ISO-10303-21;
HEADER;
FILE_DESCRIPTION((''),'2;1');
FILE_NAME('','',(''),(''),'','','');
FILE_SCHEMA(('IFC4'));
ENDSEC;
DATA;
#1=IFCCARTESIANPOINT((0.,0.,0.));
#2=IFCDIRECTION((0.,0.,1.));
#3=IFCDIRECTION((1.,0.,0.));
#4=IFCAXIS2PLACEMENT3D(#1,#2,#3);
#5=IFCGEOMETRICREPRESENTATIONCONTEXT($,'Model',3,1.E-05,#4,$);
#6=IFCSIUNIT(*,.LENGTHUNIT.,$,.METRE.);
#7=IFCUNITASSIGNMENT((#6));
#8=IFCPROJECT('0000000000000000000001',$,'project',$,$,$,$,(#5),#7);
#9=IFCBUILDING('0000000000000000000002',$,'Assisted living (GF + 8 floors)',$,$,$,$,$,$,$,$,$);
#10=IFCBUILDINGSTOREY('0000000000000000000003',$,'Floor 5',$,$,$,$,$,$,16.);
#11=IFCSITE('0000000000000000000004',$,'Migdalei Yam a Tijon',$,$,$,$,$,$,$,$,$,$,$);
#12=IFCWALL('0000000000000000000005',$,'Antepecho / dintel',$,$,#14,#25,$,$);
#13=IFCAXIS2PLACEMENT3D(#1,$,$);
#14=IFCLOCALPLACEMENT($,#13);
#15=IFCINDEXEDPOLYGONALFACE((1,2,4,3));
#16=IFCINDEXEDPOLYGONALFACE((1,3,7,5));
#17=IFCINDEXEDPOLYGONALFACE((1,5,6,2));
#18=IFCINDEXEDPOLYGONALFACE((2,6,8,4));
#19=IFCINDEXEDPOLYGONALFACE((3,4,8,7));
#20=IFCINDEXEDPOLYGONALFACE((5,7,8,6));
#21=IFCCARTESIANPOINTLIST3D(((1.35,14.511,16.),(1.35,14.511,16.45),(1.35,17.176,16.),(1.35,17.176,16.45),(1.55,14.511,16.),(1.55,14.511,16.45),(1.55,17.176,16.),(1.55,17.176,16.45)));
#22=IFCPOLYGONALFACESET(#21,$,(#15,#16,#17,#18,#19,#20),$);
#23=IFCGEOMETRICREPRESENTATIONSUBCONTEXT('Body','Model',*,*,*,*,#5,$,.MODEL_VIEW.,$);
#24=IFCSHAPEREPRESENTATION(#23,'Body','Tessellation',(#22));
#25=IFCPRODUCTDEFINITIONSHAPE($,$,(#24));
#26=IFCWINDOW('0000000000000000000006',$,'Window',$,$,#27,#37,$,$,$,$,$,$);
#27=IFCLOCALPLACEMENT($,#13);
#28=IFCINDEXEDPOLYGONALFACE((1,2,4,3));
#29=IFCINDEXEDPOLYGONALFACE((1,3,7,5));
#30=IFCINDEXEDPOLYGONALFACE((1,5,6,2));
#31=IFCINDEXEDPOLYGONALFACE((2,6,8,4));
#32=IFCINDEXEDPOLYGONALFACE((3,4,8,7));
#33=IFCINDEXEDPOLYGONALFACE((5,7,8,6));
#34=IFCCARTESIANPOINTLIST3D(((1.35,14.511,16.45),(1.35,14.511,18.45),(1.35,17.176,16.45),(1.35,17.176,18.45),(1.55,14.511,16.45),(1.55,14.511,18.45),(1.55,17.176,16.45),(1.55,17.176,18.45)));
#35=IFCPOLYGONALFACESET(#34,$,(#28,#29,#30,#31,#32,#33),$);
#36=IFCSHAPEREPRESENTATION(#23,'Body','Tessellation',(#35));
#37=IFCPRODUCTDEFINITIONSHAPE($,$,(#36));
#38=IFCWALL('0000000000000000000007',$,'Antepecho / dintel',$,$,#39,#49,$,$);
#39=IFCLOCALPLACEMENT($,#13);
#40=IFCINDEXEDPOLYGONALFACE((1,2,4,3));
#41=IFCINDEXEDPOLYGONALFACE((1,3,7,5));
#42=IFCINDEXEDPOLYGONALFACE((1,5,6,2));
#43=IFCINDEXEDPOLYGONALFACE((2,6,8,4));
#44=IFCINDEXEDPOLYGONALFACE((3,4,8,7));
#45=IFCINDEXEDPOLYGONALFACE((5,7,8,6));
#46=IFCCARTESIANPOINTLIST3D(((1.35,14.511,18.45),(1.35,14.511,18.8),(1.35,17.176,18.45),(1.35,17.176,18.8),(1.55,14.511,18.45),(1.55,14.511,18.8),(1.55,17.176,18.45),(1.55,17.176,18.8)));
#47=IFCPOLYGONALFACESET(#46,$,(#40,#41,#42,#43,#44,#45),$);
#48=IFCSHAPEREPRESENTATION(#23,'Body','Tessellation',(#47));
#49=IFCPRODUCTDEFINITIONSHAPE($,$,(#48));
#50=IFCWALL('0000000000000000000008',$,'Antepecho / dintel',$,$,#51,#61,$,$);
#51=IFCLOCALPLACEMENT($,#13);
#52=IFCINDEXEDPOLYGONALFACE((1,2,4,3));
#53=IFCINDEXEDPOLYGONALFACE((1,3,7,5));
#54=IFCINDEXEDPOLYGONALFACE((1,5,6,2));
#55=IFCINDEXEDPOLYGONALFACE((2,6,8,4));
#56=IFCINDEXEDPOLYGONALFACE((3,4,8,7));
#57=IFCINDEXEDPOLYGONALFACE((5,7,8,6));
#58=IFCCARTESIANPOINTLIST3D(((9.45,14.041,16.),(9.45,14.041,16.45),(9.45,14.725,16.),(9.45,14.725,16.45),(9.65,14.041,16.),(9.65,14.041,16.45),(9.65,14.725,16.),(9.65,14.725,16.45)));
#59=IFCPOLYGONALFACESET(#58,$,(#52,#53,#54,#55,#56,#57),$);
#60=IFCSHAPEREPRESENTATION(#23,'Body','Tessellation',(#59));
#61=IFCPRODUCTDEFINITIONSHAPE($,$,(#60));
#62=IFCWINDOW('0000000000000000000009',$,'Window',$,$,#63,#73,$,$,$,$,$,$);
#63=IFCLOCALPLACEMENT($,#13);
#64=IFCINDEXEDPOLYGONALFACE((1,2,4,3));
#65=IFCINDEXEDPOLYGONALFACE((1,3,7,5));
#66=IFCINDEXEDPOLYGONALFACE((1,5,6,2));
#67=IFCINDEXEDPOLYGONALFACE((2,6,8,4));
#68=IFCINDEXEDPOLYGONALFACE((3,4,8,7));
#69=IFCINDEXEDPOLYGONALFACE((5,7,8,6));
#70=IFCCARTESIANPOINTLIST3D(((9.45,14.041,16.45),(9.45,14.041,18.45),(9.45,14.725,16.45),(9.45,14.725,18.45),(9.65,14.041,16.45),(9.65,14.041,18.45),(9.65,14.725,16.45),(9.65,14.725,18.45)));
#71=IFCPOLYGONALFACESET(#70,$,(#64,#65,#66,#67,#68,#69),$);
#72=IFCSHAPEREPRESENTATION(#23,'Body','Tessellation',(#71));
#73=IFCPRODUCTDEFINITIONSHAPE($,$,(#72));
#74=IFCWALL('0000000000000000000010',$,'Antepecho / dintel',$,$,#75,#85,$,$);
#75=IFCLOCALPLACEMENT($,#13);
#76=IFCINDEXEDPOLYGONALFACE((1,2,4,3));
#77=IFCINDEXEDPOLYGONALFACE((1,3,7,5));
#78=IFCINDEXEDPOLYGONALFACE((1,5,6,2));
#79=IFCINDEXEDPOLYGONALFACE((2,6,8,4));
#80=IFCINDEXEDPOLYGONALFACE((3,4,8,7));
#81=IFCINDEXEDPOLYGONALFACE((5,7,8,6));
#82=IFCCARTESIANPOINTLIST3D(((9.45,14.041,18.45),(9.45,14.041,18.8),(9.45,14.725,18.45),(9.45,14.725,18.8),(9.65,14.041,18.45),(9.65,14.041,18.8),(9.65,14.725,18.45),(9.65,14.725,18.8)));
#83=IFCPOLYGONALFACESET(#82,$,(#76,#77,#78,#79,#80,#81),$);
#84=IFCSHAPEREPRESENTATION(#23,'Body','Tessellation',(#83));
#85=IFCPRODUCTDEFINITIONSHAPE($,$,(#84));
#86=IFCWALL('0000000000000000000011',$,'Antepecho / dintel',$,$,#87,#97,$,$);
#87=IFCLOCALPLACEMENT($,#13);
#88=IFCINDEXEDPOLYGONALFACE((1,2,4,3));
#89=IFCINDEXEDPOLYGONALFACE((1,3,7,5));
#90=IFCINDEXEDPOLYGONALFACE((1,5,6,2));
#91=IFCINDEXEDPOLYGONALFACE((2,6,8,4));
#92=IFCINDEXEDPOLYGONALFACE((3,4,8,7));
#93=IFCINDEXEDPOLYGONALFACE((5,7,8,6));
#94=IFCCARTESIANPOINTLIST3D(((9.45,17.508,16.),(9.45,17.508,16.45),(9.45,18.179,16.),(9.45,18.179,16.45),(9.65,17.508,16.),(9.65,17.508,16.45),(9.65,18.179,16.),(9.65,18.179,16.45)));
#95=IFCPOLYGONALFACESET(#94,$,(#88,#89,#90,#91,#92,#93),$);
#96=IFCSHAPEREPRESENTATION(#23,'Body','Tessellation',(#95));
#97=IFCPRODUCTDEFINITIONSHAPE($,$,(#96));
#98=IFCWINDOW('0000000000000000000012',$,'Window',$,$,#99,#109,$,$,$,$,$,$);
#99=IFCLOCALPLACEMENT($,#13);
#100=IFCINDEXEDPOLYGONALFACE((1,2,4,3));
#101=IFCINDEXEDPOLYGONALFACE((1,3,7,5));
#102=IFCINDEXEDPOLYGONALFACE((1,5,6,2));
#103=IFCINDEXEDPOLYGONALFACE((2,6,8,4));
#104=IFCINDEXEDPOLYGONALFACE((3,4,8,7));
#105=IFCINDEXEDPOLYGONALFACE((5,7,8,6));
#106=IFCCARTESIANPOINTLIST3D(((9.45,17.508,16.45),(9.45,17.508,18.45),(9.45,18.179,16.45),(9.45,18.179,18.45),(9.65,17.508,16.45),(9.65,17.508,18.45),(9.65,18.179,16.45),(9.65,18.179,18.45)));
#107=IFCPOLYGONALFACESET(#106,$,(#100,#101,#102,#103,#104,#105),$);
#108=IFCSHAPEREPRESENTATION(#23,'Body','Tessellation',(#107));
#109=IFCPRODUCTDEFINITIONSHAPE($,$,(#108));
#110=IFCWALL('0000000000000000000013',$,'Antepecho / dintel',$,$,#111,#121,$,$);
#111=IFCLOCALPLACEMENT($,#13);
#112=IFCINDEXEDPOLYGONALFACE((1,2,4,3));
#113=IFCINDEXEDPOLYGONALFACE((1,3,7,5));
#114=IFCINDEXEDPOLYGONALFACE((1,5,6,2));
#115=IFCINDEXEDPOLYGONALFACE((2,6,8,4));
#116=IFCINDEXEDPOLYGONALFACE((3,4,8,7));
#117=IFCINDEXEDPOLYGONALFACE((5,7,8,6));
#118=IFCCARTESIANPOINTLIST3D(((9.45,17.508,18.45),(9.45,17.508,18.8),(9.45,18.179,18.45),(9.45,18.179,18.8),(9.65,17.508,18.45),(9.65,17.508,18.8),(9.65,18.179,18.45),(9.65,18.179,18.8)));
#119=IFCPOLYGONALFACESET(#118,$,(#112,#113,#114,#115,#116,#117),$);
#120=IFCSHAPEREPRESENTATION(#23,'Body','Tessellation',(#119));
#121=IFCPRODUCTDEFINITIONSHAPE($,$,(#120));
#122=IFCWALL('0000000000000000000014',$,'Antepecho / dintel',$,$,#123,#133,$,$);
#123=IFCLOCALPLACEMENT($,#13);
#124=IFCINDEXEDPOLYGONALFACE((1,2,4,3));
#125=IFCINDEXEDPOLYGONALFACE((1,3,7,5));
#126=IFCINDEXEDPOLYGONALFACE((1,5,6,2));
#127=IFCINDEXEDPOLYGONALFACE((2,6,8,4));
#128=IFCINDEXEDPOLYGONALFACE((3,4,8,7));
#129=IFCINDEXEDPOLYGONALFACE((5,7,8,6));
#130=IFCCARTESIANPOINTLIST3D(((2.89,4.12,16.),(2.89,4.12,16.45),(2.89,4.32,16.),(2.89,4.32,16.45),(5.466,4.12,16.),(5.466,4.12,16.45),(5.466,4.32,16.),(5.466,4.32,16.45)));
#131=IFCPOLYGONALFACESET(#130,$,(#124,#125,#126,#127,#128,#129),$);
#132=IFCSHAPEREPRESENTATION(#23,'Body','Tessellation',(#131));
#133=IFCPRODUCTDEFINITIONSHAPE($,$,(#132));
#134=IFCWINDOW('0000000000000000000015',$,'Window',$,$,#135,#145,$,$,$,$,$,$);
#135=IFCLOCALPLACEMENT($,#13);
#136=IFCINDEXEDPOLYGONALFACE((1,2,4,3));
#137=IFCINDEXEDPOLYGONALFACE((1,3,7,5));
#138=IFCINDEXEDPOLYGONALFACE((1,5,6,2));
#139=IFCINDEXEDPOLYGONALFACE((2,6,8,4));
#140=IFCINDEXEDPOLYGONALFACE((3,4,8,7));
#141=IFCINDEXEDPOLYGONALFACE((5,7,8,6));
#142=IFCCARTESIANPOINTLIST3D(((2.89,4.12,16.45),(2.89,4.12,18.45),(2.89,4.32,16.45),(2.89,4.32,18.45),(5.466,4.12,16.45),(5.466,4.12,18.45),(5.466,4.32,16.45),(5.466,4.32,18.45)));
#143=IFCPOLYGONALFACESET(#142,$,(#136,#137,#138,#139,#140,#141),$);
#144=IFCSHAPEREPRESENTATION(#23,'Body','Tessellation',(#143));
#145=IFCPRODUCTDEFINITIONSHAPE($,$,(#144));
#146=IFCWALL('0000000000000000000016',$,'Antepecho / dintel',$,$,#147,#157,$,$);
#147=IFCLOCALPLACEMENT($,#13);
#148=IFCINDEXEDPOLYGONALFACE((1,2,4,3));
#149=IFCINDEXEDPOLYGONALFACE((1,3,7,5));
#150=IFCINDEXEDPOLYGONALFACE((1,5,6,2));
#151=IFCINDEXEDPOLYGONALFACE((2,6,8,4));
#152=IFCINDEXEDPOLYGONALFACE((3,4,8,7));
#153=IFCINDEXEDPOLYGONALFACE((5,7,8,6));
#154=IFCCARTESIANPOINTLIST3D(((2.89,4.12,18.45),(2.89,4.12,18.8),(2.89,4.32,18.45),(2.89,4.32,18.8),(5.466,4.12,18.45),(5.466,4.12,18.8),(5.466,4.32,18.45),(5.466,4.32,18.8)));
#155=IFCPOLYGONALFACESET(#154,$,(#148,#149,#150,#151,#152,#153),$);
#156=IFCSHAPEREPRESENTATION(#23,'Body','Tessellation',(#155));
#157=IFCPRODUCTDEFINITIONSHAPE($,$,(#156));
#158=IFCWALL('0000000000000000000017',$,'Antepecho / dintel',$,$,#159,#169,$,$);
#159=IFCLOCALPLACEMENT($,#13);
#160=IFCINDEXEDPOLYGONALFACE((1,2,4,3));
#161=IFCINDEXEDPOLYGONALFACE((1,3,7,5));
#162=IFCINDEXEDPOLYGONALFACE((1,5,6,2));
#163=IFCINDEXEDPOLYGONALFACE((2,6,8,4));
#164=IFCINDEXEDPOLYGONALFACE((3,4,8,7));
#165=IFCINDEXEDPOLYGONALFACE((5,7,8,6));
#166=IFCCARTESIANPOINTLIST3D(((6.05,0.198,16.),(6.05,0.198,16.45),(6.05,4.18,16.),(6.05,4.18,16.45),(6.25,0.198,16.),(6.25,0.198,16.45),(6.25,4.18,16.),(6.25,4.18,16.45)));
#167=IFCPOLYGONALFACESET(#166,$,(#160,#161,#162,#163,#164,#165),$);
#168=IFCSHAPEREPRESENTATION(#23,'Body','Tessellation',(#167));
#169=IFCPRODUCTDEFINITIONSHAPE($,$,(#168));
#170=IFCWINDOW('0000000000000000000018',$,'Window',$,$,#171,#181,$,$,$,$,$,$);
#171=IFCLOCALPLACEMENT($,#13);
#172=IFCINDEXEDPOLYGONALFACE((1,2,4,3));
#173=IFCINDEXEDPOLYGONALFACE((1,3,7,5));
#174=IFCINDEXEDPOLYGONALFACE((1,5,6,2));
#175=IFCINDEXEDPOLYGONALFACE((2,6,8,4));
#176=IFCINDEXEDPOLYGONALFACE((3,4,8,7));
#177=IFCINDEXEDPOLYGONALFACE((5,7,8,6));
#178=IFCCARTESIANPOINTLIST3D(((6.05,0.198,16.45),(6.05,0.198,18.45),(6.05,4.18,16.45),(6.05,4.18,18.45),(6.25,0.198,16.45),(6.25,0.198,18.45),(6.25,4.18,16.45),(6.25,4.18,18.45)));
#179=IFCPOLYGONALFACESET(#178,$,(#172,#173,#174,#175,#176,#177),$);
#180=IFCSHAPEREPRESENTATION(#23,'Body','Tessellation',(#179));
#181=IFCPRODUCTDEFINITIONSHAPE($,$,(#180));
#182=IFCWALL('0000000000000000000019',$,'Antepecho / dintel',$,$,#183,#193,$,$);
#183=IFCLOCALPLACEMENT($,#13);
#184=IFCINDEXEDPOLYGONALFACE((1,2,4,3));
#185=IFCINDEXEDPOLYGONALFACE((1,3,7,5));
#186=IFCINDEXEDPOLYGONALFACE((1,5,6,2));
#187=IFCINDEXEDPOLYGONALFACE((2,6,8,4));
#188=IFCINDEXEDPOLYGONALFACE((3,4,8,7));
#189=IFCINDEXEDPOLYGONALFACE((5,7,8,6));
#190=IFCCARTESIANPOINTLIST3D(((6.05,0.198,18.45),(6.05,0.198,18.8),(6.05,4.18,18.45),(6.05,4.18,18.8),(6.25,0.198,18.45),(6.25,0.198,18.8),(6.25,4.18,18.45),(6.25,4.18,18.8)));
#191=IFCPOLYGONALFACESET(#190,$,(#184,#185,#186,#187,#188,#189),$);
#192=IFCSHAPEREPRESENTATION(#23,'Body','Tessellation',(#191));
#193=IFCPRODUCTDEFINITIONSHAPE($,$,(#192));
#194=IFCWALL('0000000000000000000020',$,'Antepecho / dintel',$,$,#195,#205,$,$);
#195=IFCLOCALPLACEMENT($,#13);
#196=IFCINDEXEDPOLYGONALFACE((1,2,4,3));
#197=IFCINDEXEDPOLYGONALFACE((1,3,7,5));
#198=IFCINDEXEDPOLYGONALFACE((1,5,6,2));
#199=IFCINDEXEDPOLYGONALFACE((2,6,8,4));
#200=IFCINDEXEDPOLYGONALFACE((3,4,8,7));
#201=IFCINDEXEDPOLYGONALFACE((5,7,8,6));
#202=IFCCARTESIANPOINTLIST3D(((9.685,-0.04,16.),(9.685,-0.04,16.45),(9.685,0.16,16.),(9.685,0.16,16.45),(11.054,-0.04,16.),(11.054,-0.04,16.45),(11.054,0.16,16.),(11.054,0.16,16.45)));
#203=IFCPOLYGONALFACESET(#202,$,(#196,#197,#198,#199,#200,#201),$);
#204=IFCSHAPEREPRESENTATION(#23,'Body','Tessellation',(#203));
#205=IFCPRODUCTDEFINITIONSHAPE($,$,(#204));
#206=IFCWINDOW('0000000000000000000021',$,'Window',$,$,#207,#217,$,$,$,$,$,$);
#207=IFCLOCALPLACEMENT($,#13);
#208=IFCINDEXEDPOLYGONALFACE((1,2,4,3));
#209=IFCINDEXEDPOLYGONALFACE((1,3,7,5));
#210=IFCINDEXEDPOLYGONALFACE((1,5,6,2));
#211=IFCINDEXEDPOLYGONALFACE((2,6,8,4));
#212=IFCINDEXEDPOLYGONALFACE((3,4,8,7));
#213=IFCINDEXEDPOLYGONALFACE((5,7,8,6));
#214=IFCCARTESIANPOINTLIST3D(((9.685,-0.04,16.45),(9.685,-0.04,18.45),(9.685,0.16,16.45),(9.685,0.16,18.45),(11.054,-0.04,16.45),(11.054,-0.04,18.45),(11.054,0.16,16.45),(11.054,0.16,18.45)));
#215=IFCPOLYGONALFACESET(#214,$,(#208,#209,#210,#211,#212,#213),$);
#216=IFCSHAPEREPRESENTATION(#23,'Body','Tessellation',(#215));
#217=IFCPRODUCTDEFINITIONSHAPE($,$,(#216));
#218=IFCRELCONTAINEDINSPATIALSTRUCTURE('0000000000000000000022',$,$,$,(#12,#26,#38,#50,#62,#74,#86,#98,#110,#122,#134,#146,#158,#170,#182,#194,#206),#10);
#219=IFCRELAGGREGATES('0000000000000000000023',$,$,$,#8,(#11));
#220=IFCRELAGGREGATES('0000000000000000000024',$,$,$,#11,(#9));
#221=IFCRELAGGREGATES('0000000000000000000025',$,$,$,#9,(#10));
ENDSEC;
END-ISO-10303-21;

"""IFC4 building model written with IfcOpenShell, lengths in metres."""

from ifc_helpers import new_model, si_unit, frame, origin_with_axes, context, subcontext, project, spatial, line, indexed_curve, outline, extrude, element, save


model = new_model("IFC4")

# Units and contexts
model_context = context("Model", 3, precision=1e-05, world=origin_with_axes())
body_context = subcontext(model_context, "Body", "Model", "MODEL_VIEW")
ifc_project = project(units=[si_unit("LENGTHUNIT", "METRE")], contexts=[model_context])

# Site, building, storey
site = spatial("IfcSite", under=ifc_project, Name="Migdalei Yam a Tijon")
building = spatial("IfcBuilding", under=site, Name="Assisted living (GF + 8 floors)")
storey = spatial("IfcBuildingStorey", under=building, Name="Floor 5", Elevation=16.0)

# Wall
element("IfcWall", 1, inside=storey, Name="Antepecho / dintel", context=body_context, shape_type="SweptSolid", body=[
    extrude(outline(indexed_curve([(0.0, 0.0), (0.2, 0.0), (0.2, 2.665), (0.0, 2.665)], segments=[line(1, 2, 3, 4, 1)])), frame((1.35, 14.511, 16.0), z_axis=(0.0, 0.0, 1.0), x_axis=(1.0, 0.0, 0.0)), (0.0, 0.0, 1.0), 0.45),
])

# Window
element("IfcWindow", 2, inside=storey, Name="Window", context=body_context, shape_type="SweptSolid", body=[
    extrude(outline(indexed_curve([(0.0, 0.0), (0.2, 0.0), (0.2, 2.665), (0.0, 2.665)], segments=[line(1, 2, 3, 4, 1)])), frame((1.35, 14.511, 16.45), z_axis=(0.0, 0.0, 1.0), x_axis=(1.0, 0.0, 0.0)), (0.0, 0.0, 1.0), 2.0),
])

# Walls
element("IfcWall", 3, inside=storey, Name="Antepecho / dintel", context=body_context, shape_type="SweptSolid", body=[
    extrude(outline(indexed_curve([(0.0, 0.0), (0.2, 0.0), (0.2, 2.665), (0.0, 2.665)], segments=[line(1, 2, 3, 4, 1)])), frame((1.35, 14.511, 18.45), z_axis=(0.0, 0.0, 1.0), x_axis=(1.0, 0.0, 0.0)), (0.0, 0.0, 1.0), 0.35),
])
element("IfcWall", 4, inside=storey, Name="Antepecho / dintel", context=body_context, shape_type="SweptSolid", body=[
    extrude(outline(indexed_curve([(0.0, 0.0), (0.2, 0.0), (0.2, 0.684), (0.0, 0.684)], segments=[line(1, 2, 3, 4, 1)])), frame((9.45, 14.041, 16.0), z_axis=(0.0, 0.0, 1.0), x_axis=(1.0, 0.0, 0.0)), (0.0, 0.0, 1.0), 0.45),
])

# Window
element("IfcWindow", 5, inside=storey, Name="Window", context=body_context, shape_type="SweptSolid", body=[
    extrude(outline(indexed_curve([(0.0, 0.0), (0.2, 0.0), (0.2, 0.684), (0.0, 0.684)], segments=[line(1, 2, 3, 4, 1)])), frame((9.45, 14.041, 16.45), z_axis=(0.0, 0.0, 1.0), x_axis=(1.0, 0.0, 0.0)), (0.0, 0.0, 1.0), 2.0),
])

# Walls
element("IfcWall", 6, inside=storey, Name="Antepecho / dintel", context=body_context, shape_type="SweptSolid", body=[
    extrude(outline(indexed_curve([(0.0, 0.0), (0.2, 0.0), (0.2, 0.684), (0.0, 0.684)], segments=[line(1, 2, 3, 4, 1)])), frame((9.45, 14.041, 18.45), z_axis=(0.0, 0.0, 1.0), x_axis=(1.0, 0.0, 0.0)), (0.0, 0.0, 1.0), 0.35),
])
element("IfcWall", 7, inside=storey, Name="Antepecho / dintel", context=body_context, shape_type="SweptSolid", body=[
    extrude(outline(indexed_curve([(0.0, 0.0), (0.2, 0.0), (0.2, 0.671), (0.0, 0.671)], segments=[line(1, 2, 3, 4, 1)])), frame((9.45, 17.508, 16.0), z_axis=(0.0, 0.0, 1.0), x_axis=(1.0, 0.0, 0.0)), (0.0, 0.0, 1.0), 0.45),
])

# Window
element("IfcWindow", 8, inside=storey, Name="Window", context=body_context, shape_type="SweptSolid", body=[
    extrude(outline(indexed_curve([(0.0, 0.0), (0.2, 0.0), (0.2, 0.671), (0.0, 0.671)], segments=[line(1, 2, 3, 4, 1)])), frame((9.45, 17.508, 16.45), z_axis=(0.0, 0.0, 1.0), x_axis=(1.0, 0.0, 0.0)), (0.0, 0.0, 1.0), 2.0),
])

# Walls
element("IfcWall", 9, inside=storey, Name="Antepecho / dintel", context=body_context, shape_type="SweptSolid", body=[
    extrude(outline(indexed_curve([(0.0, 0.0), (0.2, 0.0), (0.2, 0.671), (0.0, 0.671)], segments=[line(1, 2, 3, 4, 1)])), frame((9.45, 17.508, 18.45), z_axis=(0.0, 0.0, 1.0), x_axis=(1.0, 0.0, 0.0)), (0.0, 0.0, 1.0), 0.35),
])
element("IfcWall", 10, inside=storey, Name="Antepecho / dintel", context=body_context, shape_type="SweptSolid", body=[
    extrude(outline(indexed_curve([(0.0, 0.0), (2.576, 0.0), (2.576, 0.2), (0.0, 0.2)], segments=[line(1, 2, 3, 4, 1)])), frame((2.89, 4.12, 16.0), z_axis=(0.0, 0.0, 1.0), x_axis=(1.0, 0.0, 0.0)), (0.0, 0.0, 1.0), 0.45),
])

# Window
element("IfcWindow", 11, inside=storey, Name="Window", context=body_context, shape_type="SweptSolid", body=[
    extrude(outline(indexed_curve([(0.0, 0.0), (2.576, 0.0), (2.576, 0.2), (0.0, 0.2)], segments=[line(1, 2, 3, 4, 1)])), frame((2.89, 4.12, 16.45), z_axis=(0.0, 0.0, 1.0), x_axis=(1.0, 0.0, 0.0)), (0.0, 0.0, 1.0), 2.0),
])

# Walls
element("IfcWall", 12, inside=storey, Name="Antepecho / dintel", context=body_context, shape_type="SweptSolid", body=[
    extrude(outline(indexed_curve([(0.0, 0.0), (2.576, 0.0), (2.576, 0.2), (0.0, 0.2)], segments=[line(1, 2, 3, 4, 1)])), frame((2.89, 4.12, 18.45), z_axis=(0.0, 0.0, 1.0), x_axis=(1.0, 0.0, 0.0)), (0.0, 0.0, 1.0), 0.35),
])
element("IfcWall", 13, inside=storey, Name="Antepecho / dintel", context=body_context, shape_type="SweptSolid", body=[
    extrude(outline(indexed_curve([(0.0, 0.0), (0.2, 0.0), (0.2, 3.982), (0.0, 3.982)], segments=[line(1, 2, 3, 4, 1)])), frame((6.05, 0.198, 16.0), z_axis=(0.0, 0.0, 1.0), x_axis=(1.0, 0.0, 0.0)), (0.0, 0.0, 1.0), 0.45),
])

# Window
element("IfcWindow", 14, inside=storey, Name="Window", context=body_context, shape_type="SweptSolid", body=[
    extrude(outline(indexed_curve([(0.0, 0.0), (0.2, 0.0), (0.2, 3.982), (0.0, 3.982)], segments=[line(1, 2, 3, 4, 1)])), frame((6.05, 0.198, 16.45), z_axis=(0.0, 0.0, 1.0), x_axis=(1.0, 0.0, 0.0)), (0.0, 0.0, 1.0), 2.0),
])

# Walls
element("IfcWall", 15, inside=storey, Name="Antepecho / dintel", context=body_context, shape_type="SweptSolid", body=[
    extrude(outline(indexed_curve([(0.0, 0.0), (0.2, 0.0), (0.2, 3.982), (0.0, 3.982)], segments=[line(1, 2, 3, 4, 1)])), frame((6.05, 0.198, 18.45), z_axis=(0.0, 0.0, 1.0), x_axis=(1.0, 0.0, 0.0)), (0.0, 0.0, 1.0), 0.35),
])
element("IfcWall", 16, inside=storey, Name="Antepecho / dintel", context=body_context, shape_type="SweptSolid", body=[
    extrude(outline(indexed_curve([(0.0, 0.0), (1.369, 0.0), (1.369, 0.2), (0.0, 0.2)], segments=[line(1, 2, 3, 4, 1)])), frame((9.685, -0.04, 16.0), z_axis=(0.0, 0.0, 1.0), x_axis=(1.0, 0.0, 0.0)), (0.0, 0.0, 1.0), 0.45),
])

# Window
element("IfcWindow", 17, inside=storey, Name="Window", context=body_context, shape_type="SweptSolid", body=[
    extrude(outline(indexed_curve([(0.0, 0.0), (1.369, 0.0), (1.369, 0.2), (0.0, 0.2)], segments=[line(1, 2, 3, 4, 1)])), frame((9.685, -0.04, 16.45), z_axis=(0.0, 0.0, 1.0), x_axis=(1.0, 0.0, 0.0)), (0.0, 0.0, 1.0), 2.0),
])

save(model, "model.ifc")
